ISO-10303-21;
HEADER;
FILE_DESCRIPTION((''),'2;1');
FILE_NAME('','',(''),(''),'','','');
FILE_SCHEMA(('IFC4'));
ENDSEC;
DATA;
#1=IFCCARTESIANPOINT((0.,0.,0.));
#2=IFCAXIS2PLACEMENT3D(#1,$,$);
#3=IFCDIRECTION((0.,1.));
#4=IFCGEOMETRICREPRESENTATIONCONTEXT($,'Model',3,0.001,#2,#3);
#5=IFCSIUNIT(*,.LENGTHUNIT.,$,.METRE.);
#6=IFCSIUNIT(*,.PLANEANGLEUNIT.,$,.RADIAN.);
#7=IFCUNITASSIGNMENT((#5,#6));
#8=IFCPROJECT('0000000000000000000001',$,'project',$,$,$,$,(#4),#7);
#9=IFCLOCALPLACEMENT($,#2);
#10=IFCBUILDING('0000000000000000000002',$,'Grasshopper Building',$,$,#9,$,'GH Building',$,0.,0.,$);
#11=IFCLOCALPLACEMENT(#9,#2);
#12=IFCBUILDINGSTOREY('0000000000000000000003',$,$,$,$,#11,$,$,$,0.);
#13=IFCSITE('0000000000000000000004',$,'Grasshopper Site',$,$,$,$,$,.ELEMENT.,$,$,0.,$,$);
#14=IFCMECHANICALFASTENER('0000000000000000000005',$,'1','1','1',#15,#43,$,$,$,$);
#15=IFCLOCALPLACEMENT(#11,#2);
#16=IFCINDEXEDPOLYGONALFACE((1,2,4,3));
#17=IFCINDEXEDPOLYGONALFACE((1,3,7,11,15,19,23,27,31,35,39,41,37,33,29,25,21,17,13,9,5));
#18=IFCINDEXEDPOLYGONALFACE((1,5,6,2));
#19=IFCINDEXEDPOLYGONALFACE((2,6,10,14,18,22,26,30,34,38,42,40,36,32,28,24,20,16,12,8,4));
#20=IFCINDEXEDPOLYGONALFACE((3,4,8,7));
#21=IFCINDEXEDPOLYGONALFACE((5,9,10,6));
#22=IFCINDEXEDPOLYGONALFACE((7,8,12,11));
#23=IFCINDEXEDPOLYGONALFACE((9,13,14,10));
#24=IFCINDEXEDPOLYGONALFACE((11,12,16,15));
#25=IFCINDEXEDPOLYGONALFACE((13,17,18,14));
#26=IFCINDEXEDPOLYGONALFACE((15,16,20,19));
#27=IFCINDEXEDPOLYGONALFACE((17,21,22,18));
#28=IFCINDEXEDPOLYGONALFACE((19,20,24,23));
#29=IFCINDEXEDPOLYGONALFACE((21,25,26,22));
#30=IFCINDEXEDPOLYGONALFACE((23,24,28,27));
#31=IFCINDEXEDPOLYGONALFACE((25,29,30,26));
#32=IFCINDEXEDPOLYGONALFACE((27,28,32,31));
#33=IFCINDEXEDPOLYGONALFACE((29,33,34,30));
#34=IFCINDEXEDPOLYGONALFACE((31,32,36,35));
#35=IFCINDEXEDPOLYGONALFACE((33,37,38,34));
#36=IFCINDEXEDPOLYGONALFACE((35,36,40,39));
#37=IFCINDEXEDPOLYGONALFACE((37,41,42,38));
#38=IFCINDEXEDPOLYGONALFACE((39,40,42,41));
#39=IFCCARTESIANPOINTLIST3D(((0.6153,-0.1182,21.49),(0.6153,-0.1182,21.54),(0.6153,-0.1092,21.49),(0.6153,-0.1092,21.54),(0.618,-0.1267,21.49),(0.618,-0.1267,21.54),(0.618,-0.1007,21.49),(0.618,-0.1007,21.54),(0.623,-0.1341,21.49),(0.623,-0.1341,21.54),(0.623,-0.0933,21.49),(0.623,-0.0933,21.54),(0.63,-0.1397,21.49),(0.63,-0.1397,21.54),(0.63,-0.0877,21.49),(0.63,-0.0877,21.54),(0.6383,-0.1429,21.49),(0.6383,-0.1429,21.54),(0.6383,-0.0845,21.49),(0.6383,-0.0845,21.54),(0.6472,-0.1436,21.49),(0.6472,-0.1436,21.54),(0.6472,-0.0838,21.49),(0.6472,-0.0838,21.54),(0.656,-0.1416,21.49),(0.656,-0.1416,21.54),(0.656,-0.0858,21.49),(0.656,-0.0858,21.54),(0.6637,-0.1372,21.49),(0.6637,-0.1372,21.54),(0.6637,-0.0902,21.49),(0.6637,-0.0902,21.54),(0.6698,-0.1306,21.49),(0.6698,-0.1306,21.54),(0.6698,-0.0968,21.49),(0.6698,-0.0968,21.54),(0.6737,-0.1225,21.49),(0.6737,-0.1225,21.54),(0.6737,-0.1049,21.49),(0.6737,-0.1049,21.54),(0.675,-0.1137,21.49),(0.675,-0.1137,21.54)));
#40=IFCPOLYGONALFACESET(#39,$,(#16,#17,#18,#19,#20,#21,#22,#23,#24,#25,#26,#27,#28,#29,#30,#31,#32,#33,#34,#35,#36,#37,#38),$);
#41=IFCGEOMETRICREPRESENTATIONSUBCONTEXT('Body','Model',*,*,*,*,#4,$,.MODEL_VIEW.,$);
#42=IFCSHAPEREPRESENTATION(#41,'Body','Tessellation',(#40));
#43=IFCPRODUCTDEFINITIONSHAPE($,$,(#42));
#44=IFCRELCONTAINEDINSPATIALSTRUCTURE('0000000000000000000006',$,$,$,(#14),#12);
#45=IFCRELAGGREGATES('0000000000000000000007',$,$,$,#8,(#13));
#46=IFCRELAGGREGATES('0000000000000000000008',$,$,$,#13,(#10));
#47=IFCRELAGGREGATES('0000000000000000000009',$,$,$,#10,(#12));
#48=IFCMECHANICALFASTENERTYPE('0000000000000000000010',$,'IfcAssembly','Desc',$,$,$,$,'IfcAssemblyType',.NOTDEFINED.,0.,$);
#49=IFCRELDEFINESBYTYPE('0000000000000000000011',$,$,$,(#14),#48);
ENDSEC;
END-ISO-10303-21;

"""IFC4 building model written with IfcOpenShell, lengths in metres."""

from ifc_helpers import new_model, si_unit, direction, frame, origin, place, context, subcontext, project, spatial, circle, extrude, source, transform, mapped, type_object, type_shapes, element, save


model = new_model("IFC4")

# Units and contexts
model_context = context("Model", 3, precision=0.001, world=origin(), true_north=direction((0.0, 1.0)))
body_context = subcontext(model_context, "Body", "Model", "MODEL_VIEW")
ifc_project = project(units=[si_unit("LENGTHUNIT", "METRE"), si_unit("PLANEANGLEUNIT", "RADIAN")], contexts=[model_context])

# Site, building, storey
site = spatial("IfcSite", under=ifc_project, Name="Grasshopper Site", CompositionType="ELEMENT", RefElevation=0.0)
building_placement = place(None, origin())
building = spatial("IfcBuilding", under=site, at=building_placement, Name="Grasshopper Building", LongName="GH Building", ElevationOfRefHeight=0.0, ElevationOfTerrain=0.0)
storey_placement = place(building_placement, origin())
storey = spatial("IfcBuildingStorey", under=building, at=storey_placement, Elevation=0.0)

# Mechanical fastener
mechanical_fastener_type_1 = type_object("IfcMechanicalFastenerType", Name="IfcAssembly", Description="Desc", ElementType="IfcAssemblyType", NominalDiameter=0.0)
shared_shape_1 = source(origin(), body_context, "Body", "SweptSolid", [
    extrude(circle(Radius=0.03), frame((0.645, -0.1137, 21.54), z_axis=(0.0, 0.0, -1.0), x_axis=(1.0, 0.0, 0.0)), (0.0, 0.0, 1.0), 0.05),
])
type_shapes(mechanical_fastener_type_1, [shared_shape_1])
mechanical_fastener_1_placement = place(storey_placement, origin())
element("IfcMechanicalFastener", 1, at=mechanical_fastener_1_placement, inside=storey, type_object=mechanical_fastener_type_1, Name="1", Description="1", ObjectType="1", context=body_context, shape_type="MappedRepresentation", body=[
    mapped(shared_shape_1, transform((0.0, 0.0, 0.0), scale=1.0)),
])

save(model, "model.ifc")
